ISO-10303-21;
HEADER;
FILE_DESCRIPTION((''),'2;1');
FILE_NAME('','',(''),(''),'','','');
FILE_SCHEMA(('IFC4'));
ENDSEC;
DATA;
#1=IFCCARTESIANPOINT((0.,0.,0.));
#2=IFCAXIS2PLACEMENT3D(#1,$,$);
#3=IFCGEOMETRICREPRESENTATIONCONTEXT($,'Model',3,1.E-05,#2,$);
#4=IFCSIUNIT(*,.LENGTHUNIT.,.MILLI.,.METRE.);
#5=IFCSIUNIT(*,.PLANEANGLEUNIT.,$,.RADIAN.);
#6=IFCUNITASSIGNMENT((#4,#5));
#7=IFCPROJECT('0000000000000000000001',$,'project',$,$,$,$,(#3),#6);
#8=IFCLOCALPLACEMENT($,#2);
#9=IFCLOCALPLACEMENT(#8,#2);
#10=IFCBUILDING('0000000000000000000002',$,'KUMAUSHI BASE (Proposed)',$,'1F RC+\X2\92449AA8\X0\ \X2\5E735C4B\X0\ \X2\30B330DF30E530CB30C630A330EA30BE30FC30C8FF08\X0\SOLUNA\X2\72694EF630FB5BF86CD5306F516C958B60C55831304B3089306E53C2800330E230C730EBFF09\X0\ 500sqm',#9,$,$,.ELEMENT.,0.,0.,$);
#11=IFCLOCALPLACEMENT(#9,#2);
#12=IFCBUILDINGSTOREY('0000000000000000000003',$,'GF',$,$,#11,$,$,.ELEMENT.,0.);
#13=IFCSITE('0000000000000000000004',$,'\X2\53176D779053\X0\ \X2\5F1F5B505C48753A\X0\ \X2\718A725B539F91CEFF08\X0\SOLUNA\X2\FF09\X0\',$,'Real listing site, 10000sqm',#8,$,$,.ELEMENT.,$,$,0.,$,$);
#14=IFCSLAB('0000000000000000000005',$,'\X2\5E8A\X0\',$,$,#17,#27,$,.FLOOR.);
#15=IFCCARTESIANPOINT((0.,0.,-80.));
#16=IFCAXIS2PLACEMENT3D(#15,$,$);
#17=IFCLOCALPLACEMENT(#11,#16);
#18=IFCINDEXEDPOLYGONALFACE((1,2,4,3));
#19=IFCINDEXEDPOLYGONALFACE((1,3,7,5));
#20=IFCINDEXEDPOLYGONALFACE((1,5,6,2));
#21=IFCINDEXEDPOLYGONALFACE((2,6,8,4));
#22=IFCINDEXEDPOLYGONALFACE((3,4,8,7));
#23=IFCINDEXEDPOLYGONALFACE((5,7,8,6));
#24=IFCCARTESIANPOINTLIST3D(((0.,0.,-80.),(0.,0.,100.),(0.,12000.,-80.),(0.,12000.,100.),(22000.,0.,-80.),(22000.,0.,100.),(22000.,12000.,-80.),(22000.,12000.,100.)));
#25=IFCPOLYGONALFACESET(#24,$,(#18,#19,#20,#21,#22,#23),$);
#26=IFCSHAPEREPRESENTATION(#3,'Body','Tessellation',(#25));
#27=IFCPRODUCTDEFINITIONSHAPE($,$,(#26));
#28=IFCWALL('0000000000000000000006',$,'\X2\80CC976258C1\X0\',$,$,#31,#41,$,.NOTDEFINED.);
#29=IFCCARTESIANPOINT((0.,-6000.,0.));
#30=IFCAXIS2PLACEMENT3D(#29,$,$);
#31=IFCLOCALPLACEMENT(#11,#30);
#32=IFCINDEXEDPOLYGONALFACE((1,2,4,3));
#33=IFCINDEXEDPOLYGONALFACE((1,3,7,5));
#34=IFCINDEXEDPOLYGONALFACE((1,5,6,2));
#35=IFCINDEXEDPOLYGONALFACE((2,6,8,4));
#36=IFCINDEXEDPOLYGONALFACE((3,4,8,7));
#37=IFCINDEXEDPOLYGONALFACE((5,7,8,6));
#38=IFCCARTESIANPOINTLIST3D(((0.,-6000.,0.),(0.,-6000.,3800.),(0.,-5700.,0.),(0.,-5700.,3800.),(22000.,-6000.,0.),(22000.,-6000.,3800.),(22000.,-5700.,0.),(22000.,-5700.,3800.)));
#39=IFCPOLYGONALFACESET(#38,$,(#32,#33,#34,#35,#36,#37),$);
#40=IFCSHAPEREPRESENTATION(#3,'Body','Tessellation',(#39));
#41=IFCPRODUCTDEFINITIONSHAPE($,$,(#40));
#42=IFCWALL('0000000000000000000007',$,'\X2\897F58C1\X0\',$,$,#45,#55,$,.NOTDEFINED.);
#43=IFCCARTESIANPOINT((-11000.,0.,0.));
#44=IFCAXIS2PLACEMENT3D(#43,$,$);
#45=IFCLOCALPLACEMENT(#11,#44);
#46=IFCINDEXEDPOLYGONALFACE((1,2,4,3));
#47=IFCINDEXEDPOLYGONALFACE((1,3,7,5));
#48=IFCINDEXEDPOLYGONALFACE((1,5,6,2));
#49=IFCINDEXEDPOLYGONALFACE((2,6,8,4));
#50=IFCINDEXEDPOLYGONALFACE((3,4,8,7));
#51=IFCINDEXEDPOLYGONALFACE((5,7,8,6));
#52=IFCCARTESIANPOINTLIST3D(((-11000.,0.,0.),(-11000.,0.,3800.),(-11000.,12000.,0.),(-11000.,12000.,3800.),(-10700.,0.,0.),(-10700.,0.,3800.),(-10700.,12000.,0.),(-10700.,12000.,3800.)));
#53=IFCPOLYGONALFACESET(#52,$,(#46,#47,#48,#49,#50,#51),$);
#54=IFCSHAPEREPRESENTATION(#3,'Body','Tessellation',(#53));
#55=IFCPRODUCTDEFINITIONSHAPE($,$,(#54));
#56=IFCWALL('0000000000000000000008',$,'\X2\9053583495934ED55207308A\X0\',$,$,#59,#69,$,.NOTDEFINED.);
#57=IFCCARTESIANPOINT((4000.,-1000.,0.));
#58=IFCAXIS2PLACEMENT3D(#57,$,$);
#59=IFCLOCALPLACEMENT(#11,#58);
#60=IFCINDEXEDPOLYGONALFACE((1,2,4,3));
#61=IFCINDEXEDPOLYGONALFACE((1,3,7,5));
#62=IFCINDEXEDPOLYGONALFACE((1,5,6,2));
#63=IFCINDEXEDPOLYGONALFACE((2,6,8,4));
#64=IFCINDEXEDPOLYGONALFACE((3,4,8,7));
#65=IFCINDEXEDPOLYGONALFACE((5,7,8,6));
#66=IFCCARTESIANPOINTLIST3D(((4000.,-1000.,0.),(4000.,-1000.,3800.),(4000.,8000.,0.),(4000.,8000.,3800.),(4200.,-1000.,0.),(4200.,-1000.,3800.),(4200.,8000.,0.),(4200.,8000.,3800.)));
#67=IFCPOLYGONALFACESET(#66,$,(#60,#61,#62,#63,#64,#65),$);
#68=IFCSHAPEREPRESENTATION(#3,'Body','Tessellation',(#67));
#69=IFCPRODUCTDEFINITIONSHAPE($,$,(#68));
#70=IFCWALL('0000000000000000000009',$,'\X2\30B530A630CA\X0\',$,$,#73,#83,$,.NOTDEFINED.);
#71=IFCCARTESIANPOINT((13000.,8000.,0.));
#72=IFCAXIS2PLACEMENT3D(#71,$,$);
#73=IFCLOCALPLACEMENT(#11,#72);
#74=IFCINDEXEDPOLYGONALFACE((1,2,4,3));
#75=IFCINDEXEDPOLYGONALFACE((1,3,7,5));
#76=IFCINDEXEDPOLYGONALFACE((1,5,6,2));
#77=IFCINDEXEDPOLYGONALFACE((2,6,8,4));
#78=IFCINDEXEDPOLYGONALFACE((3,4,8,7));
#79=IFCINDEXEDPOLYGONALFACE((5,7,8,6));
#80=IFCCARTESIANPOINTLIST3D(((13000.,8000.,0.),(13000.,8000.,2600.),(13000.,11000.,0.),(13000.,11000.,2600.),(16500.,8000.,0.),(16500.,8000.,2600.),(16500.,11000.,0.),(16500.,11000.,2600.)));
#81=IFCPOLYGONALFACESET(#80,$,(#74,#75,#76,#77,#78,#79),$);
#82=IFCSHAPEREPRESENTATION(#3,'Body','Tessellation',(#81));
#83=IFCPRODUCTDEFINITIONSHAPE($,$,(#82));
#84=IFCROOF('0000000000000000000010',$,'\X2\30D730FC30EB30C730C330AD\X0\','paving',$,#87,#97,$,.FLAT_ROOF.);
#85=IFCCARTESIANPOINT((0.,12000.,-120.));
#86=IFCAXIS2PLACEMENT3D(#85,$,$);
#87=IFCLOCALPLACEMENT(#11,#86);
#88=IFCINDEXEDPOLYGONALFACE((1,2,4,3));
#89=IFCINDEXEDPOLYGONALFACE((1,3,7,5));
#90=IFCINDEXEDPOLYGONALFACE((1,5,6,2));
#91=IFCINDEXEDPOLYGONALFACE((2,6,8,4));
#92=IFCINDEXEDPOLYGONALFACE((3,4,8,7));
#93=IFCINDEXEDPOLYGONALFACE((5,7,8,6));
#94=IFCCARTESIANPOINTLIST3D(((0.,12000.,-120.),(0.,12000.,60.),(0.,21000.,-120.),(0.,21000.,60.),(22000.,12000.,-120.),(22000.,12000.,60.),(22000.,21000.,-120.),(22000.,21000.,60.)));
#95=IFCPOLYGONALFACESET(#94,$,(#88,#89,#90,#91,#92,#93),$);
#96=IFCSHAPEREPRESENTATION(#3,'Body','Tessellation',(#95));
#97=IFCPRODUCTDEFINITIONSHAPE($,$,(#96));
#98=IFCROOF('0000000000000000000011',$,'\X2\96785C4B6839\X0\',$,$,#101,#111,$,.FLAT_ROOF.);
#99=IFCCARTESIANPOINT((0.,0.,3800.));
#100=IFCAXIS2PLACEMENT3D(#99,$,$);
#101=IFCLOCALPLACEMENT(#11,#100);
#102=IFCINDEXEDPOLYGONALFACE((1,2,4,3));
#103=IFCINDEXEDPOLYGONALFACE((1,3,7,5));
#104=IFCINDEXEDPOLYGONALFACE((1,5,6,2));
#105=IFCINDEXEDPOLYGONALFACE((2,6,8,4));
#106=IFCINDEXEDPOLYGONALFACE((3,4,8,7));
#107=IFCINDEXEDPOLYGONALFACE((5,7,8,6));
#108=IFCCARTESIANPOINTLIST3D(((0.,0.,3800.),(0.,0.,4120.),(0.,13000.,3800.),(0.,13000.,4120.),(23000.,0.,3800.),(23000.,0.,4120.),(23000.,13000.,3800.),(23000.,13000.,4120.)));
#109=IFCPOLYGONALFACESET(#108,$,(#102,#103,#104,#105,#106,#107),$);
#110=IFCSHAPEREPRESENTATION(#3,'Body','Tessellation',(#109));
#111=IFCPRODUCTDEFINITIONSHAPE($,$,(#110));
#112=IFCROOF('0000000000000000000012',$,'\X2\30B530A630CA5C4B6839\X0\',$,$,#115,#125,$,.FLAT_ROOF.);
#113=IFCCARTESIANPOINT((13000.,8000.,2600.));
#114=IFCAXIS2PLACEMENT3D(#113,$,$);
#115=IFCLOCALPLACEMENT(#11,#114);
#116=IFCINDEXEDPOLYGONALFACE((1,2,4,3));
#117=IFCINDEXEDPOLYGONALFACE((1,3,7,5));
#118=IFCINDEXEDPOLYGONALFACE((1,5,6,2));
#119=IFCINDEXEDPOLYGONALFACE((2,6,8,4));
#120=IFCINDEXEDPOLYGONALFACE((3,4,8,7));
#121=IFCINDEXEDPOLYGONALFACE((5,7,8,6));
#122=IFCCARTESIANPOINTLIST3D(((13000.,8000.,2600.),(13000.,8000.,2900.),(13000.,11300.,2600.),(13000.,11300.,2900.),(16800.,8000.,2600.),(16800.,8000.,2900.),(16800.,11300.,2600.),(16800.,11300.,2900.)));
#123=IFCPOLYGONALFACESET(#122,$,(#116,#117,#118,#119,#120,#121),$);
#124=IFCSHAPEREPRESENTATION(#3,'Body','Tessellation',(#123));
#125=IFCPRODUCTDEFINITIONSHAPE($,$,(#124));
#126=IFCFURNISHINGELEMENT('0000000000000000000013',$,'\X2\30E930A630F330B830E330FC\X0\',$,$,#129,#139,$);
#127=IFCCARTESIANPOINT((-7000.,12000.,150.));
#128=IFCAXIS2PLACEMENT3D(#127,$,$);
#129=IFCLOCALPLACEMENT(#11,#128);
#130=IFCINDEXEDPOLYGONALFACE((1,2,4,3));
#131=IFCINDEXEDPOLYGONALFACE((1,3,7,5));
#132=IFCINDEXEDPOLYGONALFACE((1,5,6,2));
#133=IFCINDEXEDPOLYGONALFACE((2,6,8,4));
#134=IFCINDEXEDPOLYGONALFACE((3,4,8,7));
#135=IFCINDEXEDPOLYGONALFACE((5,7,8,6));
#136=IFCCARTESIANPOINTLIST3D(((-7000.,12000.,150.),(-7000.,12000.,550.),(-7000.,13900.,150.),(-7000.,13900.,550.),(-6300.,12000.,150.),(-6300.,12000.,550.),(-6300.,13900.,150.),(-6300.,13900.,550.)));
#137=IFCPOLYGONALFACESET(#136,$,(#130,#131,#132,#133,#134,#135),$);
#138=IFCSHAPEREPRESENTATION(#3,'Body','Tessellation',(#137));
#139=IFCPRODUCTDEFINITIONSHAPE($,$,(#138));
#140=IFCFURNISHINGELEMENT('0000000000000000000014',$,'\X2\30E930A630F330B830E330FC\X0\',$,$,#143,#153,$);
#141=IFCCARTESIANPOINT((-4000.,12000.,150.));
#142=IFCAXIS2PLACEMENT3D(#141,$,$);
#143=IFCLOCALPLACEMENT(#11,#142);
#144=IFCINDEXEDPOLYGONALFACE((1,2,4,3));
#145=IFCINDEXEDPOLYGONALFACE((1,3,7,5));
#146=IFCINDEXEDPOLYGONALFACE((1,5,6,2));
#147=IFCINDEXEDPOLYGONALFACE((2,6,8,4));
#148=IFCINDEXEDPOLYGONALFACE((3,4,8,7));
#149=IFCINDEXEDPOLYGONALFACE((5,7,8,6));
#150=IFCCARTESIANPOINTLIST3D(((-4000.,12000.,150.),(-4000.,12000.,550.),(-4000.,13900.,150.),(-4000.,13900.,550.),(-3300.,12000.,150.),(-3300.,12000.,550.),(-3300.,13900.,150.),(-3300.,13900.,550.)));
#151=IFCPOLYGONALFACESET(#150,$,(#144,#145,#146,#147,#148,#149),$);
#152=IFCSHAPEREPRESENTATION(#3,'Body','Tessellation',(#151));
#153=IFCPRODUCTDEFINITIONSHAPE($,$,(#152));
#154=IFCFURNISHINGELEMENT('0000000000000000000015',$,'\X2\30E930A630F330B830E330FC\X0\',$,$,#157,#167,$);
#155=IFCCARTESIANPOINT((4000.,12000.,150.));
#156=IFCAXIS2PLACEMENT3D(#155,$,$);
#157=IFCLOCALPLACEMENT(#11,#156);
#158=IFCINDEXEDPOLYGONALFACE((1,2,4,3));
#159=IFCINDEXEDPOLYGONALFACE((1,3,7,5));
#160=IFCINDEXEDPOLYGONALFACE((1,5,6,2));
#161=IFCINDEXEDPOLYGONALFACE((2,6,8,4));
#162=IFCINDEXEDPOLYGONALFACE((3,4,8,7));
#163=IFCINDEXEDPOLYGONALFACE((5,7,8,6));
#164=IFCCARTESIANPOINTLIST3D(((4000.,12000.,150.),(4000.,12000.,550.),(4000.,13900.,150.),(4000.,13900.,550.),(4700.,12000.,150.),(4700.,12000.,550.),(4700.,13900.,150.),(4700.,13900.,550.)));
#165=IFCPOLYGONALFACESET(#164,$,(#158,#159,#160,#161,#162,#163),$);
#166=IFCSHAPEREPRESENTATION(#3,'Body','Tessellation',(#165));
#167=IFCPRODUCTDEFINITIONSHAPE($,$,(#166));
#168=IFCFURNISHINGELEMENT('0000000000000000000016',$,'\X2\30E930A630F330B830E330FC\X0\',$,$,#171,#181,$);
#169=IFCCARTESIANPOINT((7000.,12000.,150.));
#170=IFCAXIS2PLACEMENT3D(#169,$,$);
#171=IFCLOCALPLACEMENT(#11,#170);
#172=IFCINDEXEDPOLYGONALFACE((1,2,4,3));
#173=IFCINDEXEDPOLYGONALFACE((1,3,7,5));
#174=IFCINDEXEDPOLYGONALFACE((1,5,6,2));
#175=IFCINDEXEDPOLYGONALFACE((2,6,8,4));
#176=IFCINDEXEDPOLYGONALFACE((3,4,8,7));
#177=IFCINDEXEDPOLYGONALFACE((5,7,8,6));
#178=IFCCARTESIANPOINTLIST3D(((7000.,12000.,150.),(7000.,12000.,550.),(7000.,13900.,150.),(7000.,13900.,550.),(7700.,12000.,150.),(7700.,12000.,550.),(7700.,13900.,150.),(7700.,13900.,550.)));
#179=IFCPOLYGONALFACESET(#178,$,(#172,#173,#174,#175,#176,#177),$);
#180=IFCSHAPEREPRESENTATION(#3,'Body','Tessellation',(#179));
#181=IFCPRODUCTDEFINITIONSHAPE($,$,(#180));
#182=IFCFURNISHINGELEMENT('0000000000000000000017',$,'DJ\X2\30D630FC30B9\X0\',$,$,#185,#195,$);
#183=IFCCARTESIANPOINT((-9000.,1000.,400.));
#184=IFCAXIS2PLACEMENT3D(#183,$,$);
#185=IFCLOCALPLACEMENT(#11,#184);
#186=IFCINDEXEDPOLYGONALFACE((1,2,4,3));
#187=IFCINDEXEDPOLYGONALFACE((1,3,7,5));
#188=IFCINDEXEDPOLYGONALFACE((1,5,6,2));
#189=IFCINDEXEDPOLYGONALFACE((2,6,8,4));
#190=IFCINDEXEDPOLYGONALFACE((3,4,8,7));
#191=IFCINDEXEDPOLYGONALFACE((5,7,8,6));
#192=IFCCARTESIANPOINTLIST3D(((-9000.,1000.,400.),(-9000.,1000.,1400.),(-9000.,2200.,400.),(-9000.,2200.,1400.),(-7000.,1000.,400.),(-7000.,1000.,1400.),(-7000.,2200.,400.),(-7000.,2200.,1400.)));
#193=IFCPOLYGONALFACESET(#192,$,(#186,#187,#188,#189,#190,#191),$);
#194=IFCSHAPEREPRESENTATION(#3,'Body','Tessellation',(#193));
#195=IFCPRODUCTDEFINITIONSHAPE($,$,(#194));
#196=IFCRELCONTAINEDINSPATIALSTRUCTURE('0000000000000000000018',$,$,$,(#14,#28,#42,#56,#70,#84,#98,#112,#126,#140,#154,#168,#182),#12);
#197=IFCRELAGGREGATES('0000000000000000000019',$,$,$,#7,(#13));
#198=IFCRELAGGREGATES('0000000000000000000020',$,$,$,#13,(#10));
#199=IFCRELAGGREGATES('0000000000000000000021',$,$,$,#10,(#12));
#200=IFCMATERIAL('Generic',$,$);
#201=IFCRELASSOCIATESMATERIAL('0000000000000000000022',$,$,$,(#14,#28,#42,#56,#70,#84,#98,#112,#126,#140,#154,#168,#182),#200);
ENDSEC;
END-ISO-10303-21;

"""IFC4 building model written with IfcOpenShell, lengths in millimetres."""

from ifc_helpers import new_model, si_unit, frame, frame_2d, origin, place, context, project, spatial, rectangle, extrude, material, element, save


model = new_model("IFC4")

# Units and contexts
model_context = context("Model", 3, precision=1e-05, world=origin())
ifc_project = project(units=[si_unit("LENGTHUNIT", "METRE", prefix="MILLI"), si_unit("PLANEANGLEUNIT", "RADIAN")], contexts=[model_context])

# Site, building, storey
site_placement = place(None, origin())
site = spatial("IfcSite", under=ifc_project, at=site_placement, Name="北海道 弟子屈町 熊牛原野（SOLUNA）", ObjectType="Real listing site, 10000sqm", CompositionType="ELEMENT", RefElevation=0.0)
building_placement = place(site_placement, origin())
building = spatial("IfcBuilding", under=site, at=building_placement, Name="KUMAUSHI BASE (Proposed)", ObjectType="1F RC+鉄骨 平屋 コミュニティリゾート（SOLUNA物件・寸法は公開情報からの参考モデル） 500sqm", CompositionType="ELEMENT", ElevationOfRefHeight=0.0, ElevationOfTerrain=0.0)
storey_placement = place(building_placement, origin())
storey = spatial("IfcBuildingStorey", under=building, at=storey_placement, Name="GF", CompositionType="ELEMENT", Elevation=0.0)

# Slab
ifc_material_1 = material(Name="Generic")
slab_1_placement = place(storey_placement, frame((0.0, 0.0, -80.0)))
element("IfcSlab", 1, at=slab_1_placement, inside=storey, material=ifc_material_1, Name="床", PredefinedType="FLOOR", context=model_context, shape_type="SweptSolid", body=[
    extrude(rectangle(XDim=22000.0, YDim=12000.0, at=frame_2d((11000.0, 6000.0))), frame((0.0, 0.0, -80.0)), (0.0, 0.0, 1.0), 180.0),
])

# Walls
wall_1_placement = place(storey_placement, frame((0.0, -6000.0, 0.0)))
element("IfcWall", 2, at=wall_1_placement, inside=storey, material=ifc_material_1, Name="背面壁", PredefinedType="NOTDEFINED", context=model_context, shape_type="SweptSolid", body=[
    extrude(rectangle(XDim=22000.0, YDim=300.0, at=frame_2d((11000.0, 150.0))), frame((0.0, -6000.0, 0.0)), (0.0, 0.0, 1.0), 3800.0),
])
wall_2_placement = place(storey_placement, frame((-11000.0, 0.0, 0.0)))
element("IfcWall", 3, at=wall_2_placement, inside=storey, material=ifc_material_1, Name="西壁", PredefinedType="NOTDEFINED", context=model_context, shape_type="SweptSolid", body=[
    extrude(rectangle(XDim=300.0, YDim=12000.0, at=frame_2d((150.0, 6000.0))), frame((-11000.0, 0.0, 0.0)), (0.0, 0.0, 1.0), 3800.0),
])

# Walls
wall_3_placement = place(storey_placement, frame((4000.0, -1000.0, 0.0)))
element("IfcWall", 4, at=wall_3_placement, inside=storey, material=ifc_material_1, Name="道場間仕切り", PredefinedType="NOTDEFINED", context=model_context, shape_type="SweptSolid", body=[
    extrude(rectangle(XDim=200.0, YDim=9000.0, at=frame_2d((100.0, 4500.0))), frame((4000.0, -1000.0, 0.0)), (0.0, 0.0, 1.0), 3800.0),
])
wall_4_placement = place(storey_placement, frame((13000.0, 8000.0, 0.0)))
element("IfcWall", 5, at=wall_4_placement, inside=storey, material=ifc_material_1, Name="サウナ", PredefinedType="NOTDEFINED", context=model_context, shape_type="SweptSolid", body=[
    extrude(rectangle(XDim=3500.0, YDim=3000.0, at=frame_2d((1750.0, 1500.0))), frame((13000.0, 8000.0, 0.0)), (0.0, 0.0, 1.0), 2600.0),
])

# Roofs
roof_1_placement = place(storey_placement, frame((0.0, 12000.0, -120.0)))
element("IfcRoof", 6, at=roof_1_placement, inside=storey, material=ifc_material_1, Name="プールデッキ", Description="paving", PredefinedType="FLAT_ROOF", context=model_context, shape_type="SweptSolid", body=[
    extrude(rectangle(XDim=22000.0, YDim=9000.0, at=frame_2d((11000.0, 4500.0))), frame((0.0, 12000.0, -120.0)), (0.0, 0.0, 1.0), 180.0),
])
roof_2_placement = place(storey_placement, frame((0.0, 0.0, 3800.0)))
element("IfcRoof", 7, at=roof_2_placement, inside=storey, material=ifc_material_1, Name="陸屋根", PredefinedType="FLAT_ROOF", context=model_context, shape_type="SweptSolid", body=[
    extrude(rectangle(XDim=23000.0, YDim=13000.0, at=frame_2d((11500.0, 6500.0))), frame((0.0, 0.0, 3800.0)), (0.0, 0.0, 1.0), 320.0),
])
roof_3_placement = place(storey_placement, frame((13000.0, 8000.0, 2600.0)))
element("IfcRoof", 8, at=roof_3_placement, inside=storey, material=ifc_material_1, Name="サウナ屋根", PredefinedType="FLAT_ROOF", context=model_context, shape_type="SweptSolid", body=[
    extrude(rectangle(XDim=3800.0, YDim=3300.0, at=frame_2d((1900.0, 1650.0))), frame((13000.0, 8000.0, 2600.0)), (0.0, 0.0, 1.0), 300.0),
])

# Furnishing elements
furnishing_1_placement = place(storey_placement, frame((-7000.0, 12000.0, 150.0)))
element("IfcFurnishingElement", 9, at=furnishing_1_placement, inside=storey, material=ifc_material_1, Name="ラウンジャー", context=model_context, shape_type="SweptSolid", body=[
    extrude(rectangle(XDim=700.0, YDim=1900.0, at=frame_2d((350.0, 950.0))), frame((-7000.0, 12000.0, 150.0)), (0.0, 0.0, 1.0), 400.0),
])
furnishing_2_placement = place(storey_placement, frame((-4000.0, 12000.0, 150.0)))
element("IfcFurnishingElement", 10, at=furnishing_2_placement, inside=storey, material=ifc_material_1, Name="ラウンジャー", context=model_context, shape_type="SweptSolid", body=[
    extrude(rectangle(XDim=700.0, YDim=1900.0, at=frame_2d((350.0, 950.0))), frame((-4000.0, 12000.0, 150.0)), (0.0, 0.0, 1.0), 400.0),
])
furnishing_3_placement = place(storey_placement, frame((4000.0, 12000.0, 150.0)))
element("IfcFurnishingElement", 11, at=furnishing_3_placement, inside=storey, material=ifc_material_1, Name="ラウンジャー", context=model_context, shape_type="SweptSolid", body=[
    extrude(rectangle(XDim=700.0, YDim=1900.0, at=frame_2d((350.0, 950.0))), frame((4000.0, 12000.0, 150.0)), (0.0, 0.0, 1.0), 400.0),
])
furnishing_4_placement = place(storey_placement, frame((7000.0, 12000.0, 150.0)))
element("IfcFurnishingElement", 12, at=furnishing_4_placement, inside=storey, material=ifc_material_1, Name="ラウンジャー", context=model_context, shape_type="SweptSolid", body=[
    extrude(rectangle(XDim=700.0, YDim=1900.0, at=frame_2d((350.0, 950.0))), frame((7000.0, 12000.0, 150.0)), (0.0, 0.0, 1.0), 400.0),
])
furnishing_5_placement = place(storey_placement, frame((-9000.0, 1000.0, 400.0)))
element("IfcFurnishingElement", 13, at=furnishing_5_placement, inside=storey, material=ifc_material_1, Name="DJブース", context=model_context, shape_type="SweptSolid", body=[
    extrude(rectangle(XDim=2000.0, YDim=1200.0, at=frame_2d((1000.0, 600.0))), frame((-9000.0, 1000.0, 400.0)), (0.0, 0.0, 1.0), 1000.0),
])

save(model, "model.ifc")
